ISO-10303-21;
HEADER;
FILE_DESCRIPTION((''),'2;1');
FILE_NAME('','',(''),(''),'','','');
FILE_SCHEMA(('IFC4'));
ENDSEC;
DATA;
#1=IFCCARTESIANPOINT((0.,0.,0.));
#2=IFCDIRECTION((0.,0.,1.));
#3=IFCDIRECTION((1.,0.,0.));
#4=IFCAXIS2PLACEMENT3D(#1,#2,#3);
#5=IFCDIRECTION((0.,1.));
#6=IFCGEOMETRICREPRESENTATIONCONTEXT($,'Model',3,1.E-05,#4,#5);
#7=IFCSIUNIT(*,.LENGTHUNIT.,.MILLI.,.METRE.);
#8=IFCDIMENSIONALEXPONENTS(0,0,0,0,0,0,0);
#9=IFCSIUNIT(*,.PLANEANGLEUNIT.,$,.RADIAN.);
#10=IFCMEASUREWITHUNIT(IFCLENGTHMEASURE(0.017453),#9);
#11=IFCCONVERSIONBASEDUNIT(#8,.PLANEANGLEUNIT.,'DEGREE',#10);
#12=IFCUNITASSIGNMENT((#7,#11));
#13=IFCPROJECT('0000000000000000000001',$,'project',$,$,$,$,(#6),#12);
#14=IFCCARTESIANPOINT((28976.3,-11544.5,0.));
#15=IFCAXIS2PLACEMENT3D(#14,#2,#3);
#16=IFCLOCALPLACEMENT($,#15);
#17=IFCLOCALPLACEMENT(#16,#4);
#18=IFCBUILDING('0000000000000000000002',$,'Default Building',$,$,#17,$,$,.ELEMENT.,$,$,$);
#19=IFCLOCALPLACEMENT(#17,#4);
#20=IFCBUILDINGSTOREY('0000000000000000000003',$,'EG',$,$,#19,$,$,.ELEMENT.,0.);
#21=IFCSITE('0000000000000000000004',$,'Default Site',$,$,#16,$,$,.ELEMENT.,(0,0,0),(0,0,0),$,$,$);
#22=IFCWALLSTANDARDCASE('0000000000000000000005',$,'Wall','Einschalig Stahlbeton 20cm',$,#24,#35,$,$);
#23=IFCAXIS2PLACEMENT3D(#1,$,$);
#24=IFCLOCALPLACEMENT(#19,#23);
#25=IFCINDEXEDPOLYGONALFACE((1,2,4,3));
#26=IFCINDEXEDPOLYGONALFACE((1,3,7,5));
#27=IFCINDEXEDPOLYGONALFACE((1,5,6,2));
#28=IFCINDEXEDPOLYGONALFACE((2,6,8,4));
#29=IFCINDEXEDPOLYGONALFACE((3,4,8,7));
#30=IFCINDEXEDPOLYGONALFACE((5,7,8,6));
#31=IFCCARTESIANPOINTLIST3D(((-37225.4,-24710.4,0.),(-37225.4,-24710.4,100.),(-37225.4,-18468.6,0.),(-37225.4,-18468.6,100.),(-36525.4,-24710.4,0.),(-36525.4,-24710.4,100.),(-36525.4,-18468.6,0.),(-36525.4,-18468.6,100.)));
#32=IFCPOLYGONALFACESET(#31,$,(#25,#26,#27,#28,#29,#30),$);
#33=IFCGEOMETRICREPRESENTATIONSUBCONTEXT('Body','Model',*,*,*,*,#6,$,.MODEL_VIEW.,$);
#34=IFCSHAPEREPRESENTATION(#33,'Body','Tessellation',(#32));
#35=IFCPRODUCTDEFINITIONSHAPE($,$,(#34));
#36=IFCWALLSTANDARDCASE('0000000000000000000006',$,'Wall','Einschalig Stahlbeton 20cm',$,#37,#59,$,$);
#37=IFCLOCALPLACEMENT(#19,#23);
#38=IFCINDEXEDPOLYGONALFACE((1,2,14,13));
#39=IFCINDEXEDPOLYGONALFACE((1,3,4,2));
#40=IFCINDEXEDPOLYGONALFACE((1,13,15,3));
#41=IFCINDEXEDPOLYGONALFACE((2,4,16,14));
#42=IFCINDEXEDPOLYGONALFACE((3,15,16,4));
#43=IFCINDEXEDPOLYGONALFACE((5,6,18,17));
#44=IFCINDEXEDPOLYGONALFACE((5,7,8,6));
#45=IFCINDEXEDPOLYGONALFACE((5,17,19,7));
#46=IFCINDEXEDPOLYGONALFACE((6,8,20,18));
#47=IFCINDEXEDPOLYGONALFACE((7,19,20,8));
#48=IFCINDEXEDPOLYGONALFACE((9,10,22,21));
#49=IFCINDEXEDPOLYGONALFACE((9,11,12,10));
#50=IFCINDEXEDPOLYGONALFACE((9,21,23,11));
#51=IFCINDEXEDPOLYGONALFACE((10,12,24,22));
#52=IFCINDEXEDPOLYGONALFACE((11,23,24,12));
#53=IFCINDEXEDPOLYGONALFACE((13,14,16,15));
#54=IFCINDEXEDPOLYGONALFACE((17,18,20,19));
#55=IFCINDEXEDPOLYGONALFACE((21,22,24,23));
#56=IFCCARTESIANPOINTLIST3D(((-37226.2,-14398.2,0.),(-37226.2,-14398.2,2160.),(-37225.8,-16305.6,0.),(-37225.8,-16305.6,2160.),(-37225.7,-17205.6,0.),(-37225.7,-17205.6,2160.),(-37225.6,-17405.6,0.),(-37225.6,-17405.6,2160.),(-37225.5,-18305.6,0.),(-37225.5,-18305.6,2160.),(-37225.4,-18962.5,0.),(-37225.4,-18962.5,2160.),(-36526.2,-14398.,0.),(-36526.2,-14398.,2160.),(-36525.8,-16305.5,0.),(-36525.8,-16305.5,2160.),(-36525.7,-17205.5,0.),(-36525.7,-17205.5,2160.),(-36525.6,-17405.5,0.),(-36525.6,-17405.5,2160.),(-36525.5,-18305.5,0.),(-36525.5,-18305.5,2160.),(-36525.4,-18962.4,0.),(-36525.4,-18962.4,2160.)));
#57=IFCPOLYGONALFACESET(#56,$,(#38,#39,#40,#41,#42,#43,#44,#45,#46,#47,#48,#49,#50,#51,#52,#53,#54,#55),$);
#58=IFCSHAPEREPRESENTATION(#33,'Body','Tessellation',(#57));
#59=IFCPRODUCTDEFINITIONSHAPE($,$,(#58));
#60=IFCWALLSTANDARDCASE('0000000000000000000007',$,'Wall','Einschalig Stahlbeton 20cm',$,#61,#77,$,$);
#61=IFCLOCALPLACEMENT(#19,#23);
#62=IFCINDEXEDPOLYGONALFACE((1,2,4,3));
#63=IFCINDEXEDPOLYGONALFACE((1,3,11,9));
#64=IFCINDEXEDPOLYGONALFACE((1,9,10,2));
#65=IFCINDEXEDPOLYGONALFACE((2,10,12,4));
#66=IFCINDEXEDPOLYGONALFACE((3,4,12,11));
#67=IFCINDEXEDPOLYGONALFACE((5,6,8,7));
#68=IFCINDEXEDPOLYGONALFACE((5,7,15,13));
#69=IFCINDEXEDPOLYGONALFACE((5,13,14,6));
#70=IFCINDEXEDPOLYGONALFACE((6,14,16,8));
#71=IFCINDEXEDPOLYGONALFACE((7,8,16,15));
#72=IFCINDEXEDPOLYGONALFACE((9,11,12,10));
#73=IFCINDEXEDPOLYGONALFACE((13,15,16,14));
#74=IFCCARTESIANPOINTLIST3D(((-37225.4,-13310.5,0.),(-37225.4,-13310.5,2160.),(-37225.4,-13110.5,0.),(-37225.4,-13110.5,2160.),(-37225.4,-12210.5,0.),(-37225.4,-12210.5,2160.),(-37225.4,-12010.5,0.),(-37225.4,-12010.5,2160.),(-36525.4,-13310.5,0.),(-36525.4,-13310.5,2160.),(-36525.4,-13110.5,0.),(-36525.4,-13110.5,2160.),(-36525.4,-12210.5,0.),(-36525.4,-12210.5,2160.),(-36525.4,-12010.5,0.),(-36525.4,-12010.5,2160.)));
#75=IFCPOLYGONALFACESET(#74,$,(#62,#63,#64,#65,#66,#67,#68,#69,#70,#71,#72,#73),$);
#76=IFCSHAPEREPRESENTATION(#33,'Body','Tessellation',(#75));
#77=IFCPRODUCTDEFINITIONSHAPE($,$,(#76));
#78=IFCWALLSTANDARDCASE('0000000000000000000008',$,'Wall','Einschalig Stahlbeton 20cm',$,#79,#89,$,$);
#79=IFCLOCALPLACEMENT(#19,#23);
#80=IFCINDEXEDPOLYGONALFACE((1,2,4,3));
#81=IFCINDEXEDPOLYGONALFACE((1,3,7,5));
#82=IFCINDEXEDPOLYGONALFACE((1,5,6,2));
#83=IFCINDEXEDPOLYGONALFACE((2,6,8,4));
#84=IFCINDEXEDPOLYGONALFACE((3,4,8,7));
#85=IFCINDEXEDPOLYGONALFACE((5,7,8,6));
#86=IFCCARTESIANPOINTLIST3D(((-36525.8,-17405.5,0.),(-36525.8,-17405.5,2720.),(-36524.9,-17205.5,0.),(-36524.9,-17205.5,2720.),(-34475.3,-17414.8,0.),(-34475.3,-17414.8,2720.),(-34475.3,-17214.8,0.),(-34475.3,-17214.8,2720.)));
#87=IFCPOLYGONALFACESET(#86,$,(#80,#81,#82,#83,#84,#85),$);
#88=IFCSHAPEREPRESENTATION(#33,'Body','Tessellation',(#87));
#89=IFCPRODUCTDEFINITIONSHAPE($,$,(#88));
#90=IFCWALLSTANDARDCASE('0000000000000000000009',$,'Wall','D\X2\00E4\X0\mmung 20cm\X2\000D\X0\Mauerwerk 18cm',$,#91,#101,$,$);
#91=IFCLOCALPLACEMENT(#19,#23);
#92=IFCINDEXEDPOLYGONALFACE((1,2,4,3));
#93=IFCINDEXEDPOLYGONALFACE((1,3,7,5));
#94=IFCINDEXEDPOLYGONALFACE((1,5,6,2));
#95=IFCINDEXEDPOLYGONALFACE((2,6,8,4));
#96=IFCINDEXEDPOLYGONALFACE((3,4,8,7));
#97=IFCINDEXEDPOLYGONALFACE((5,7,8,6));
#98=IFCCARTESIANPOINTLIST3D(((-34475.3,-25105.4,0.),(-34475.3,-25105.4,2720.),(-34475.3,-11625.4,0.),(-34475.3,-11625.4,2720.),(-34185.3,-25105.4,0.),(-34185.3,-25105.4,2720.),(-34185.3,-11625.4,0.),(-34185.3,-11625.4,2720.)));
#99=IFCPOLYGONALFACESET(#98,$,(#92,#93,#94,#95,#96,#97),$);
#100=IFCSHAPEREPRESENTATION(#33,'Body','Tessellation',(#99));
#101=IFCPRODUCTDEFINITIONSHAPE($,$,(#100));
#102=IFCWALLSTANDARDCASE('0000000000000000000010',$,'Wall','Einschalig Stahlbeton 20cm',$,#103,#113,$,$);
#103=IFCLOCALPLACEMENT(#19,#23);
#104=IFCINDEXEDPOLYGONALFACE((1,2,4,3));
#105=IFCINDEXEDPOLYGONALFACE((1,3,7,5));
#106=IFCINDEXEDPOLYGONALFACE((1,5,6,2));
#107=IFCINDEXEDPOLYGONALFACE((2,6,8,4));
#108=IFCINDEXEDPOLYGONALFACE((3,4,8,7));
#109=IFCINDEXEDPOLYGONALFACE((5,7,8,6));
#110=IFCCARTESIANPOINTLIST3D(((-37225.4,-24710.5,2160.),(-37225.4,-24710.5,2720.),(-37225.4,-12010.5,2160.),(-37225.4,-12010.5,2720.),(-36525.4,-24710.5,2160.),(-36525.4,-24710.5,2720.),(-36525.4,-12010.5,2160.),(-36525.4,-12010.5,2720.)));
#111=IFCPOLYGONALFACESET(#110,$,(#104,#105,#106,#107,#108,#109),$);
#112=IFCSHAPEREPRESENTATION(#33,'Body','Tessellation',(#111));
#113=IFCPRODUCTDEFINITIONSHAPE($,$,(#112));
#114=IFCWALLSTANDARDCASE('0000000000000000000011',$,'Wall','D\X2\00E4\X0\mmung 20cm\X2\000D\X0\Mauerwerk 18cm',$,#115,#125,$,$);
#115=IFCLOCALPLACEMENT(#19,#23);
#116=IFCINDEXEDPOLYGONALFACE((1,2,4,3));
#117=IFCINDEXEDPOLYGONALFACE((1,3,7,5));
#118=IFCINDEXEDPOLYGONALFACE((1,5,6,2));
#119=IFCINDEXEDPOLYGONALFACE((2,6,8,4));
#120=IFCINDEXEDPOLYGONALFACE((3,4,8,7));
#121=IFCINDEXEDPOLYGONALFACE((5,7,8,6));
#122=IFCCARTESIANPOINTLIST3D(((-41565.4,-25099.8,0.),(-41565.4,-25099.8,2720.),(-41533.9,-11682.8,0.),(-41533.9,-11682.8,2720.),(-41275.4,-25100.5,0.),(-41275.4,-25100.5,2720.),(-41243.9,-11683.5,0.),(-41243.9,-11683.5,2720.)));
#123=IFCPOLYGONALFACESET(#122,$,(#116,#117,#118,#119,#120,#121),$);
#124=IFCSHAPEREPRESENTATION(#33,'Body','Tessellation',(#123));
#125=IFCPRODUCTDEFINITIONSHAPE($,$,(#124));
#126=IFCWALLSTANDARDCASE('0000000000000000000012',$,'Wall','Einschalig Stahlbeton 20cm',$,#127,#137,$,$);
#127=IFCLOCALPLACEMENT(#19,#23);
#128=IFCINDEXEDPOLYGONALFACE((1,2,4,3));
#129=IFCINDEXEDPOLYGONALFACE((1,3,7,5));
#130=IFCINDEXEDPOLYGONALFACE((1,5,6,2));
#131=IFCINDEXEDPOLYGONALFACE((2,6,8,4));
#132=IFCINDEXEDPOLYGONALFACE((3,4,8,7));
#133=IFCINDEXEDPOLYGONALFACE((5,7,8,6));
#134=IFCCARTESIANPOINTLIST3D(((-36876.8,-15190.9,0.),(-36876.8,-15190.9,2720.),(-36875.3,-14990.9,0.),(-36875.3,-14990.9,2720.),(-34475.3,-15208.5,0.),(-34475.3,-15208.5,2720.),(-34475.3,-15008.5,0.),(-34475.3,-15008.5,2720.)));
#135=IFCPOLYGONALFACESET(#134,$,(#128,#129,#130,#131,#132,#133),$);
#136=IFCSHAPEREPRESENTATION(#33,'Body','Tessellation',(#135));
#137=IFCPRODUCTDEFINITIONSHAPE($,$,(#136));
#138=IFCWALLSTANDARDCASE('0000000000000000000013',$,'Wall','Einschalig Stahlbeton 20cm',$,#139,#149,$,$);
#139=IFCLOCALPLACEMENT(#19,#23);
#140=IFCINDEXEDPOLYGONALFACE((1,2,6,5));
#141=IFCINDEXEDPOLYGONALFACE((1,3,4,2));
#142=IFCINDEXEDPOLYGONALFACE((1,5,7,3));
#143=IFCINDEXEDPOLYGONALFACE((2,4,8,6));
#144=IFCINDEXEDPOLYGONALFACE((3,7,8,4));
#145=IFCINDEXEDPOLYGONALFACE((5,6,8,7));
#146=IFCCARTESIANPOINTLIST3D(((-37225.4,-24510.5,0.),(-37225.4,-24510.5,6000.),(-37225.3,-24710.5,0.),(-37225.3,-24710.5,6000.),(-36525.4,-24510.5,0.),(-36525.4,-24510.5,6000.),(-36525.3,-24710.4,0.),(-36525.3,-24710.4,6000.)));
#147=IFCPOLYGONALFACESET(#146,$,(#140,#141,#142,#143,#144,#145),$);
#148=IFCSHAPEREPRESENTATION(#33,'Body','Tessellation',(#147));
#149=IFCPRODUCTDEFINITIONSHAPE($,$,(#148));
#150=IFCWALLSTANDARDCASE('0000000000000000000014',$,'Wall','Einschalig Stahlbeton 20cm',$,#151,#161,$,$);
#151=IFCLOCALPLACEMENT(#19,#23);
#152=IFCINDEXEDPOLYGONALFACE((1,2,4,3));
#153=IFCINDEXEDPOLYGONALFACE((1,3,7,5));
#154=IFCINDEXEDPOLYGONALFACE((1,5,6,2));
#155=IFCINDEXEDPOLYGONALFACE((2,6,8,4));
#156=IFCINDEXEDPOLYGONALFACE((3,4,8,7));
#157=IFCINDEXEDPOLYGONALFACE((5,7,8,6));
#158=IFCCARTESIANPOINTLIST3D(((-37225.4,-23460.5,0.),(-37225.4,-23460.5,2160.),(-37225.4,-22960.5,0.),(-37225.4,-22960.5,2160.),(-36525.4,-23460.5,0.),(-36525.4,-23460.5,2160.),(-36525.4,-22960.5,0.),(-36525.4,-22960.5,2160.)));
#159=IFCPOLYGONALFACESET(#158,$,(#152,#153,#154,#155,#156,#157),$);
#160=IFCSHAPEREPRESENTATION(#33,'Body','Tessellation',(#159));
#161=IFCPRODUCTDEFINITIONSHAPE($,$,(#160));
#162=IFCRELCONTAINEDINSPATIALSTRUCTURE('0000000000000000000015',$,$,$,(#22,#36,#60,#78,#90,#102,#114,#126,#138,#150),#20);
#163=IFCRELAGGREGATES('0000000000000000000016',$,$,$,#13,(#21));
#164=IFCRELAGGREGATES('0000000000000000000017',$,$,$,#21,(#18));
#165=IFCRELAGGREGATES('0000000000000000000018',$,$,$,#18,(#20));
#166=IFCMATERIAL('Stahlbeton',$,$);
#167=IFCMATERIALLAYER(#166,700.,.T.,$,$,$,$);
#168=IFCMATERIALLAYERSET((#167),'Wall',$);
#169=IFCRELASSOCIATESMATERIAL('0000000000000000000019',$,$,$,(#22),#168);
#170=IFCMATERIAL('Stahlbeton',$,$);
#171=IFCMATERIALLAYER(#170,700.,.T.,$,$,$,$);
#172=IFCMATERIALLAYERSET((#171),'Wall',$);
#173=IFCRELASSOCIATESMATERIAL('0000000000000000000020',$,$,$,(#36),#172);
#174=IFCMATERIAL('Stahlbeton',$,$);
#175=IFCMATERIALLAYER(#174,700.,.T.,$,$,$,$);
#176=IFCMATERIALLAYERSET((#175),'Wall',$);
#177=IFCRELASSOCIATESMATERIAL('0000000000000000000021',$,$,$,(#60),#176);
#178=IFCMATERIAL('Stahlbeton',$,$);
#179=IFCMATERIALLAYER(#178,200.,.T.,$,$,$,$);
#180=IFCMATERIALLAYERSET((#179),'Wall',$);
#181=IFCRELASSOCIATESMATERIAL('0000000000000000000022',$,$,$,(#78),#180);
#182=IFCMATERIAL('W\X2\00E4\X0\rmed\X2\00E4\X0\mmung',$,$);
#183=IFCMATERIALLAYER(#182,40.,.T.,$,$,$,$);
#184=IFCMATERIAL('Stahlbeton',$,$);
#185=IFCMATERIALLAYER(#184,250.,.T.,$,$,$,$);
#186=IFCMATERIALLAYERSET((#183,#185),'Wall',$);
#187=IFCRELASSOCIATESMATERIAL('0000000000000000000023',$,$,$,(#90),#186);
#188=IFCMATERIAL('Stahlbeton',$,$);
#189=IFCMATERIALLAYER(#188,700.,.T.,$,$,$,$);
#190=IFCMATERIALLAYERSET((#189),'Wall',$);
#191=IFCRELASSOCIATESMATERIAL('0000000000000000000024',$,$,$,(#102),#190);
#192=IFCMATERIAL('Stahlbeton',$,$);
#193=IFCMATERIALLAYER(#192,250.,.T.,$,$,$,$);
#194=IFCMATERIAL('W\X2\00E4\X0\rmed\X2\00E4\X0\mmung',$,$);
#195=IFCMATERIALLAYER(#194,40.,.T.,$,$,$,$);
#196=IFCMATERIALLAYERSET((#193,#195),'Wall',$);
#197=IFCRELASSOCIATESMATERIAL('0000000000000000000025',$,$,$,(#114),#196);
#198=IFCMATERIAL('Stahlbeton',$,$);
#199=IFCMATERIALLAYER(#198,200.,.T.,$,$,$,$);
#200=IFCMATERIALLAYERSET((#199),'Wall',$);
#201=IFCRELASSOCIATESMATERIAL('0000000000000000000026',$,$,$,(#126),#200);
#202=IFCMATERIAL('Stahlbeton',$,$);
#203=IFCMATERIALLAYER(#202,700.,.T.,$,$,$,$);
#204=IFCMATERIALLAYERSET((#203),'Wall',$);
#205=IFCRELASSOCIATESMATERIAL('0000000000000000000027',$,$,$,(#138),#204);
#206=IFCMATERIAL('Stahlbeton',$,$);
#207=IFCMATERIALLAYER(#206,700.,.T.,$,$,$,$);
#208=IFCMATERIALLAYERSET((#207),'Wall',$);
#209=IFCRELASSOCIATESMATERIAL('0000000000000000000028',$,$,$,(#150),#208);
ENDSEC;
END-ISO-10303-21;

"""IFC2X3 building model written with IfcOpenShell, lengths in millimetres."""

from ifc_helpers import new_model, entity, si_unit, converted_unit, direction, frame, origin_with_axes, place, context, subcontext, project, spatial, polyline, outline, extrude, material, layer, layer_set, layer_usage, element, save


model = new_model("IFC2X3")

# Units and contexts
model_context = context("Model", 3, precision=1e-05, world=origin_with_axes(), true_north=direction((0.0, 1.0)))
body_context = subcontext(model_context, "Body", "Model", "MODEL_VIEW")
ifc_project = project(units=[si_unit("LENGTHUNIT", "METRE", prefix="MILLI"), converted_unit("PLANEANGLEUNIT", "DEGREE", entity("IfcLengthMeasure", 0.017453), si_unit("PLANEANGLEUNIT", "RADIAN"), dimensions=[0, 0, 0, 0, 0, 0, 0])], contexts=[model_context])

# Site, building, storey
site_placement = place(None, frame((28976.3, -11544.5, 0.0), z_axis=(0.0, 0.0, 1.0), x_axis=(1.0, 0.0, 0.0)))
site = spatial("IfcSite", under=ifc_project, at=site_placement, Name="Default Site", CompositionType="ELEMENT", RefLatitude=(0, 0, 0), RefLongitude=(0, 0, 0))
building_placement = place(site_placement, origin_with_axes())
building = spatial("IfcBuilding", under=site, at=building_placement, Name="Default Building", CompositionType="ELEMENT")
storey_placement = place(building_placement, origin_with_axes())
storey = spatial("IfcBuildingStorey", under=building, at=storey_placement, Name="EG", CompositionType="ELEMENT", Elevation=0.0)

# Wall
ifc_material_1 = material(Name="Stahlbeton")
ifc_layer_1 = layer(ifc_material_1, 700.0, ventilated=True)
ifc_layer_set_1 = layer_set([ifc_layer_1], Name="Wall")
ifc_layer_usage_1 = layer_usage(ifc_layer_set_1, "AXIS2", "POSITIVE", -350.0)
wall_1_placement = place(storey_placement, frame((-36875.4, -24710.4, 0.0), z_axis=(0.0, 0.0, 1.0), x_axis=(0.0, 1.0, 0.0)))
element("IfcWallStandardCase", 1, at=wall_1_placement, inside=storey, material=ifc_layer_usage_1, Name="Wall", Description="Einschalig Stahlbeton 20cm", context=body_context, shape_type="SweptSolid", body=[
    extrude(outline(polyline([(0.0, -350.0), (0.0, 350.0), (6241.8, 350.0), (6241.8, -350.0), (0.0, -350.0)])), origin_with_axes(), (0.0, 0.0, 1.0), 100.0),
])

# Wall, openings
ifc_material_2 = material(Name="Stahlbeton")
ifc_layer_2 = layer(ifc_material_2, 700.0, ventilated=True)
ifc_layer_set_2 = layer_set([ifc_layer_2], Name="Wall")
ifc_layer_usage_2 = layer_usage(ifc_layer_set_2, "AXIS2", "POSITIVE", -350.0)
wall_2_placement = place(storey_placement, frame((-36875.4, -18962.5, 0.0), z_axis=(0.0, 0.0, 1.0), x_axis=(-0.000176, 1.0, 0.0)))
wall_2 = element("IfcWallStandardCase", 2, at=wall_2_placement, inside=storey, material=ifc_layer_usage_2, Name="Wall", Description="Einschalig Stahlbeton 20cm", context=body_context, shape_type="SweptSolid", body=[
    extrude(outline(polyline([(0.0, -350.0), (0.0, 350.0), (4564.3, 350.0), (4564.3, -350.0), (0.0, -350.0)])), origin_with_axes(), (0.0, 0.0, 1.0), 2160.0),
])
opening_1_placement = place(wall_2_placement, frame((2656.9, 0.0, 0.0), z_axis=(0.0, -1.0, 0.0), x_axis=(0.0, 0.0, 1.0)))
element("IfcOpeningElement", 3, at=opening_1_placement, cuts=wall_2, context=body_context, shape_type="SweptSolid", body=[
    extrude(outline(polyline([(0.0, 0.0), (2160.0, 0.0), (2160.0, 900.0), (0.0, 900.0), (0.0, 0.0), (0.0, 0.0)])), frame((0.0, 0.0, 700.0), z_axis=(0.0, 0.0, 1.0), x_axis=(1.0, 0.0, 0.0)), (0.0, 0.0, -1.0), 1400.0),
])
opening_2_placement = place(wall_2_placement, frame((656.9, 0.0, 0.0), z_axis=(0.0, 1.0, 0.0), x_axis=(0.0, 0.0, 1.0)))
element("IfcOpeningElement", 4, at=opening_2_placement, cuts=wall_2, context=body_context, shape_type="SweptSolid", body=[
    extrude(outline(polyline([(0.0, 0.0), (2160.0, 0.0), (2160.0, 900.0), (0.0, 900.0), (0.0, 0.0), (0.0, 0.0)])), frame((0.0, 0.0, 700.0), z_axis=(0.0, 0.0, 1.0), x_axis=(1.0, 0.0, 0.0)), (0.0, 0.0, -1.0), 1400.0),
])

# Wall, opening
ifc_material_3 = material(Name="Stahlbeton")
ifc_layer_3 = layer(ifc_material_3, 700.0, ventilated=True)
ifc_layer_set_3 = layer_set([ifc_layer_3], Name="Wall")
ifc_layer_usage_3 = layer_usage(ifc_layer_set_3, "AXIS2", "POSITIVE", -350.0)
wall_3_placement = place(storey_placement, frame((-36875.4, -13310.5, 0.0), z_axis=(0.0, 0.0, 1.0), x_axis=(0.0, 1.0, 0.0)))
wall_3 = element("IfcWallStandardCase", 5, at=wall_3_placement, inside=storey, material=ifc_layer_usage_3, Name="Wall", Description="Einschalig Stahlbeton 20cm", context=body_context, shape_type="SweptSolid", body=[
    extrude(outline(polyline([(0.0, -350.0), (0.0, 350.0), (1300.0, 350.0), (1300.0, -350.0), (0.0, -350.0)])), origin_with_axes(), (0.0, 0.0, 1.0), 2160.0),
])
opening_3_placement = place(wall_3_placement, frame((1100.0, 0.0, 0.0), z_axis=(0.0, -1.0, 0.0), x_axis=(0.0, 0.0, 1.0)))
element("IfcOpeningElement", 6, at=opening_3_placement, cuts=wall_3, context=body_context, shape_type="SweptSolid", body=[
    extrude(outline(polyline([(0.0, 0.0), (2160.0, 0.0), (2160.0, 900.0), (0.0, 900.0), (0.0, 0.0), (0.0, 0.0)])), frame((0.0, 0.0, 700.0), z_axis=(0.0, 0.0, 1.0), x_axis=(1.0, 0.0, 0.0)), (0.0, 0.0, -1.0), 1400.0),
])

# Walls
ifc_material_4 = material(Name="Stahlbeton")
ifc_layer_4 = layer(ifc_material_4, 200.0, ventilated=True)
ifc_layer_set_4 = layer_set([ifc_layer_4], Name="Wall")
ifc_layer_usage_4 = layer_usage(ifc_layer_set_4, "AXIS2", "POSITIVE", -100.0)
wall_4_placement = place(storey_placement, frame((-36525.4, -17305.5, 0.0), z_axis=(0.0, 0.0, 1.0), x_axis=(0.99999, -0.004536, 0.0)))
element("IfcWallStandardCase", 7, at=wall_4_placement, inside=storey, material=ifc_layer_usage_4, Name="Wall", Description="Einschalig Stahlbeton 20cm", context=body_context, shape_type="SweptSolid", body=[
    extrude(outline(polyline([(2050.5, -100.0), (2049.6, 100.0), (0.0, 100.0), (0.0, -100.0), (2050.5, -100.0)])), origin_with_axes(), (0.0, 0.0, 1.0), 2720.0),
])
ifc_material_5 = material(Name="Wärmedämmung")
ifc_layer_5 = layer(ifc_material_5, 40.0, ventilated=True)
ifc_material_6 = material(Name="Stahlbeton")
ifc_layer_6 = layer(ifc_material_6, 250.0, ventilated=True)
ifc_layer_set_5 = layer_set([ifc_layer_5, ifc_layer_6], Name="Wall")
ifc_layer_usage_5 = layer_usage(ifc_layer_set_5, "AXIS2", "POSITIVE", -145.0)
wall_5_placement = place(storey_placement, frame((-34330.3, -11625.4, 0.0), z_axis=(0.0, 0.0, 1.0), x_axis=(0.0, -1.0, 0.0)))
element("IfcWallStandardCase", 8, at=wall_5_placement, inside=storey, material=ifc_layer_usage_5, Name="Wall", Description="Dämmung 20cm\rMauerwerk 18cm", context=body_context, shape_type="SweptSolid", body=[
    extrude(outline(polyline([(0.0, -145.0), (0.0, 145.0), (13480.0, 145.0), (13480.0, -145.0), (0.0, -145.0)])), origin_with_axes(), (0.0, 0.0, 1.0), 2720.0),
])
ifc_material_7 = material(Name="Stahlbeton")
ifc_layer_7 = layer(ifc_material_7, 700.0, ventilated=True)
ifc_layer_set_6 = layer_set([ifc_layer_7], Name="Wall")
ifc_layer_usage_6 = layer_usage(ifc_layer_set_6, "AXIS2", "POSITIVE", -350.0)
wall_6_placement = place(storey_placement, frame((-36875.4, -12010.5, 2160.0), z_axis=(0.0, 0.0, 1.0), x_axis=(0.0, -1.0, 0.0)))
element("IfcWallStandardCase", 9, at=wall_6_placement, inside=storey, material=ifc_layer_usage_6, Name="Wall", Description="Einschalig Stahlbeton 20cm", context=body_context, shape_type="SweptSolid", body=[
    extrude(outline(polyline([(0.0, -350.0), (0.0, 350.0), (12700.0, 350.0), (12700.0, -350.0), (0.0, -350.0)])), origin_with_axes(), (0.0, 0.0, 1.0), 560.0),
])
ifc_material_8 = material(Name="Stahlbeton")
ifc_layer_8 = layer(ifc_material_8, 250.0, ventilated=True)
ifc_material_9 = material(Name="Wärmedämmung")
ifc_layer_9 = layer(ifc_material_9, 40.0, ventilated=True)
ifc_layer_set_7 = layer_set([ifc_layer_8, ifc_layer_9], Name="Wall")
ifc_layer_usage_7 = layer_usage(ifc_layer_set_7, "AXIS2", "POSITIVE", -145.0)
wall_7_placement = place(storey_placement, frame((-41420.4, -25100.1, 0.0), z_axis=(0.0, 0.0, 1.0), x_axis=(0.002348, 0.999997, 0.0)))
element("IfcWallStandardCase", 10, at=wall_7_placement, inside=storey, material=ifc_layer_usage_7, Name="Wall", Description="Dämmung 20cm\rMauerwerk 18cm", context=body_context, shape_type="SweptSolid", body=[
    extrude(outline(polyline([(0.0, -145.0), (0.0, 145.0), (13417.0, 145.0), (13417.0, -145.0), (0.0, -145.0)])), origin_with_axes(), (0.0, 0.0, 1.0), 2720.0),
])
ifc_material_10 = material(Name="Stahlbeton")
ifc_layer_10 = layer(ifc_material_10, 200.0, ventilated=True)
ifc_layer_set_8 = layer_set([ifc_layer_10], Name="Wall")
ifc_layer_usage_8 = layer_usage(ifc_layer_set_8, "AXIS2", "POSITIVE", -100.0)
wall_8_placement = place(storey_placement, frame((-36876.0, -15090.9, 0.0), z_axis=(0.0, 0.0, 1.0), x_axis=(0.999973, -0.007317, 0.0)))
element("IfcWallStandardCase", 11, at=wall_8_placement, inside=storey, material=ifc_layer_usage_8, Name="Wall", Description="Einschalig Stahlbeton 20cm", context=body_context, shape_type="SweptSolid", body=[
    extrude(outline(polyline([(2401.5, -100.0), (2400.1, 100.0), (0.0, 100.0), (0.0, -100.0), (2401.5, -100.0)])), origin_with_axes(), (0.0, 0.0, 1.0), 2720.0),
])
ifc_material_11 = material(Name="Stahlbeton")
ifc_layer_11 = layer(ifc_material_11, 700.0, ventilated=True)
ifc_layer_set_9 = layer_set([ifc_layer_11], Name="Wall")
ifc_layer_usage_9 = layer_usage(ifc_layer_set_9, "AXIS2", "POSITIVE", -350.0)
wall_9_placement = place(storey_placement, frame((-36875.3, -24710.5, 0.0), z_axis=(0.0, 0.0, 1.0), x_axis=(-0.000019, 1.0, 0.0)))
element("IfcWallStandardCase", 12, at=wall_9_placement, inside=storey, material=ifc_layer_usage_9, Name="Wall", Description="Einschalig Stahlbeton 20cm", context=body_context, shape_type="SweptSolid", body=[
    extrude(outline(polyline([(0.0, -350.0), (0.0, 350.0), (200.0, 350.0), (200.0, -350.0), (0.0, -350.0)])), origin_with_axes(), (0.0, 0.0, 1.0), 6000.0),
])
ifc_material_12 = material(Name="Stahlbeton")
ifc_layer_12 = layer(ifc_material_12, 700.0, ventilated=True)
ifc_layer_set_10 = layer_set([ifc_layer_12], Name="Wall")
ifc_layer_usage_10 = layer_usage(ifc_layer_set_10, "AXIS2", "POSITIVE", -350.0)
wall_10_placement = place(storey_placement, frame((-36875.4, -23460.5, 0.0), z_axis=(0.0, 0.0, 1.0), x_axis=(0.0, 1.0, 0.0)))
element("IfcWallStandardCase", 13, at=wall_10_placement, inside=storey, material=ifc_layer_usage_10, Name="Wall", Description="Einschalig Stahlbeton 20cm", context=body_context, shape_type="SweptSolid", body=[
    extrude(outline(polyline([(0.0, 350.0), (0.0, -350.0), (500.0, -350.0), (500.0, 350.0), (0.0, 350.0)])), origin_with_axes(), (0.0, 0.0, 1.0), 2160.0),
])

save(model, "model.ifc")
